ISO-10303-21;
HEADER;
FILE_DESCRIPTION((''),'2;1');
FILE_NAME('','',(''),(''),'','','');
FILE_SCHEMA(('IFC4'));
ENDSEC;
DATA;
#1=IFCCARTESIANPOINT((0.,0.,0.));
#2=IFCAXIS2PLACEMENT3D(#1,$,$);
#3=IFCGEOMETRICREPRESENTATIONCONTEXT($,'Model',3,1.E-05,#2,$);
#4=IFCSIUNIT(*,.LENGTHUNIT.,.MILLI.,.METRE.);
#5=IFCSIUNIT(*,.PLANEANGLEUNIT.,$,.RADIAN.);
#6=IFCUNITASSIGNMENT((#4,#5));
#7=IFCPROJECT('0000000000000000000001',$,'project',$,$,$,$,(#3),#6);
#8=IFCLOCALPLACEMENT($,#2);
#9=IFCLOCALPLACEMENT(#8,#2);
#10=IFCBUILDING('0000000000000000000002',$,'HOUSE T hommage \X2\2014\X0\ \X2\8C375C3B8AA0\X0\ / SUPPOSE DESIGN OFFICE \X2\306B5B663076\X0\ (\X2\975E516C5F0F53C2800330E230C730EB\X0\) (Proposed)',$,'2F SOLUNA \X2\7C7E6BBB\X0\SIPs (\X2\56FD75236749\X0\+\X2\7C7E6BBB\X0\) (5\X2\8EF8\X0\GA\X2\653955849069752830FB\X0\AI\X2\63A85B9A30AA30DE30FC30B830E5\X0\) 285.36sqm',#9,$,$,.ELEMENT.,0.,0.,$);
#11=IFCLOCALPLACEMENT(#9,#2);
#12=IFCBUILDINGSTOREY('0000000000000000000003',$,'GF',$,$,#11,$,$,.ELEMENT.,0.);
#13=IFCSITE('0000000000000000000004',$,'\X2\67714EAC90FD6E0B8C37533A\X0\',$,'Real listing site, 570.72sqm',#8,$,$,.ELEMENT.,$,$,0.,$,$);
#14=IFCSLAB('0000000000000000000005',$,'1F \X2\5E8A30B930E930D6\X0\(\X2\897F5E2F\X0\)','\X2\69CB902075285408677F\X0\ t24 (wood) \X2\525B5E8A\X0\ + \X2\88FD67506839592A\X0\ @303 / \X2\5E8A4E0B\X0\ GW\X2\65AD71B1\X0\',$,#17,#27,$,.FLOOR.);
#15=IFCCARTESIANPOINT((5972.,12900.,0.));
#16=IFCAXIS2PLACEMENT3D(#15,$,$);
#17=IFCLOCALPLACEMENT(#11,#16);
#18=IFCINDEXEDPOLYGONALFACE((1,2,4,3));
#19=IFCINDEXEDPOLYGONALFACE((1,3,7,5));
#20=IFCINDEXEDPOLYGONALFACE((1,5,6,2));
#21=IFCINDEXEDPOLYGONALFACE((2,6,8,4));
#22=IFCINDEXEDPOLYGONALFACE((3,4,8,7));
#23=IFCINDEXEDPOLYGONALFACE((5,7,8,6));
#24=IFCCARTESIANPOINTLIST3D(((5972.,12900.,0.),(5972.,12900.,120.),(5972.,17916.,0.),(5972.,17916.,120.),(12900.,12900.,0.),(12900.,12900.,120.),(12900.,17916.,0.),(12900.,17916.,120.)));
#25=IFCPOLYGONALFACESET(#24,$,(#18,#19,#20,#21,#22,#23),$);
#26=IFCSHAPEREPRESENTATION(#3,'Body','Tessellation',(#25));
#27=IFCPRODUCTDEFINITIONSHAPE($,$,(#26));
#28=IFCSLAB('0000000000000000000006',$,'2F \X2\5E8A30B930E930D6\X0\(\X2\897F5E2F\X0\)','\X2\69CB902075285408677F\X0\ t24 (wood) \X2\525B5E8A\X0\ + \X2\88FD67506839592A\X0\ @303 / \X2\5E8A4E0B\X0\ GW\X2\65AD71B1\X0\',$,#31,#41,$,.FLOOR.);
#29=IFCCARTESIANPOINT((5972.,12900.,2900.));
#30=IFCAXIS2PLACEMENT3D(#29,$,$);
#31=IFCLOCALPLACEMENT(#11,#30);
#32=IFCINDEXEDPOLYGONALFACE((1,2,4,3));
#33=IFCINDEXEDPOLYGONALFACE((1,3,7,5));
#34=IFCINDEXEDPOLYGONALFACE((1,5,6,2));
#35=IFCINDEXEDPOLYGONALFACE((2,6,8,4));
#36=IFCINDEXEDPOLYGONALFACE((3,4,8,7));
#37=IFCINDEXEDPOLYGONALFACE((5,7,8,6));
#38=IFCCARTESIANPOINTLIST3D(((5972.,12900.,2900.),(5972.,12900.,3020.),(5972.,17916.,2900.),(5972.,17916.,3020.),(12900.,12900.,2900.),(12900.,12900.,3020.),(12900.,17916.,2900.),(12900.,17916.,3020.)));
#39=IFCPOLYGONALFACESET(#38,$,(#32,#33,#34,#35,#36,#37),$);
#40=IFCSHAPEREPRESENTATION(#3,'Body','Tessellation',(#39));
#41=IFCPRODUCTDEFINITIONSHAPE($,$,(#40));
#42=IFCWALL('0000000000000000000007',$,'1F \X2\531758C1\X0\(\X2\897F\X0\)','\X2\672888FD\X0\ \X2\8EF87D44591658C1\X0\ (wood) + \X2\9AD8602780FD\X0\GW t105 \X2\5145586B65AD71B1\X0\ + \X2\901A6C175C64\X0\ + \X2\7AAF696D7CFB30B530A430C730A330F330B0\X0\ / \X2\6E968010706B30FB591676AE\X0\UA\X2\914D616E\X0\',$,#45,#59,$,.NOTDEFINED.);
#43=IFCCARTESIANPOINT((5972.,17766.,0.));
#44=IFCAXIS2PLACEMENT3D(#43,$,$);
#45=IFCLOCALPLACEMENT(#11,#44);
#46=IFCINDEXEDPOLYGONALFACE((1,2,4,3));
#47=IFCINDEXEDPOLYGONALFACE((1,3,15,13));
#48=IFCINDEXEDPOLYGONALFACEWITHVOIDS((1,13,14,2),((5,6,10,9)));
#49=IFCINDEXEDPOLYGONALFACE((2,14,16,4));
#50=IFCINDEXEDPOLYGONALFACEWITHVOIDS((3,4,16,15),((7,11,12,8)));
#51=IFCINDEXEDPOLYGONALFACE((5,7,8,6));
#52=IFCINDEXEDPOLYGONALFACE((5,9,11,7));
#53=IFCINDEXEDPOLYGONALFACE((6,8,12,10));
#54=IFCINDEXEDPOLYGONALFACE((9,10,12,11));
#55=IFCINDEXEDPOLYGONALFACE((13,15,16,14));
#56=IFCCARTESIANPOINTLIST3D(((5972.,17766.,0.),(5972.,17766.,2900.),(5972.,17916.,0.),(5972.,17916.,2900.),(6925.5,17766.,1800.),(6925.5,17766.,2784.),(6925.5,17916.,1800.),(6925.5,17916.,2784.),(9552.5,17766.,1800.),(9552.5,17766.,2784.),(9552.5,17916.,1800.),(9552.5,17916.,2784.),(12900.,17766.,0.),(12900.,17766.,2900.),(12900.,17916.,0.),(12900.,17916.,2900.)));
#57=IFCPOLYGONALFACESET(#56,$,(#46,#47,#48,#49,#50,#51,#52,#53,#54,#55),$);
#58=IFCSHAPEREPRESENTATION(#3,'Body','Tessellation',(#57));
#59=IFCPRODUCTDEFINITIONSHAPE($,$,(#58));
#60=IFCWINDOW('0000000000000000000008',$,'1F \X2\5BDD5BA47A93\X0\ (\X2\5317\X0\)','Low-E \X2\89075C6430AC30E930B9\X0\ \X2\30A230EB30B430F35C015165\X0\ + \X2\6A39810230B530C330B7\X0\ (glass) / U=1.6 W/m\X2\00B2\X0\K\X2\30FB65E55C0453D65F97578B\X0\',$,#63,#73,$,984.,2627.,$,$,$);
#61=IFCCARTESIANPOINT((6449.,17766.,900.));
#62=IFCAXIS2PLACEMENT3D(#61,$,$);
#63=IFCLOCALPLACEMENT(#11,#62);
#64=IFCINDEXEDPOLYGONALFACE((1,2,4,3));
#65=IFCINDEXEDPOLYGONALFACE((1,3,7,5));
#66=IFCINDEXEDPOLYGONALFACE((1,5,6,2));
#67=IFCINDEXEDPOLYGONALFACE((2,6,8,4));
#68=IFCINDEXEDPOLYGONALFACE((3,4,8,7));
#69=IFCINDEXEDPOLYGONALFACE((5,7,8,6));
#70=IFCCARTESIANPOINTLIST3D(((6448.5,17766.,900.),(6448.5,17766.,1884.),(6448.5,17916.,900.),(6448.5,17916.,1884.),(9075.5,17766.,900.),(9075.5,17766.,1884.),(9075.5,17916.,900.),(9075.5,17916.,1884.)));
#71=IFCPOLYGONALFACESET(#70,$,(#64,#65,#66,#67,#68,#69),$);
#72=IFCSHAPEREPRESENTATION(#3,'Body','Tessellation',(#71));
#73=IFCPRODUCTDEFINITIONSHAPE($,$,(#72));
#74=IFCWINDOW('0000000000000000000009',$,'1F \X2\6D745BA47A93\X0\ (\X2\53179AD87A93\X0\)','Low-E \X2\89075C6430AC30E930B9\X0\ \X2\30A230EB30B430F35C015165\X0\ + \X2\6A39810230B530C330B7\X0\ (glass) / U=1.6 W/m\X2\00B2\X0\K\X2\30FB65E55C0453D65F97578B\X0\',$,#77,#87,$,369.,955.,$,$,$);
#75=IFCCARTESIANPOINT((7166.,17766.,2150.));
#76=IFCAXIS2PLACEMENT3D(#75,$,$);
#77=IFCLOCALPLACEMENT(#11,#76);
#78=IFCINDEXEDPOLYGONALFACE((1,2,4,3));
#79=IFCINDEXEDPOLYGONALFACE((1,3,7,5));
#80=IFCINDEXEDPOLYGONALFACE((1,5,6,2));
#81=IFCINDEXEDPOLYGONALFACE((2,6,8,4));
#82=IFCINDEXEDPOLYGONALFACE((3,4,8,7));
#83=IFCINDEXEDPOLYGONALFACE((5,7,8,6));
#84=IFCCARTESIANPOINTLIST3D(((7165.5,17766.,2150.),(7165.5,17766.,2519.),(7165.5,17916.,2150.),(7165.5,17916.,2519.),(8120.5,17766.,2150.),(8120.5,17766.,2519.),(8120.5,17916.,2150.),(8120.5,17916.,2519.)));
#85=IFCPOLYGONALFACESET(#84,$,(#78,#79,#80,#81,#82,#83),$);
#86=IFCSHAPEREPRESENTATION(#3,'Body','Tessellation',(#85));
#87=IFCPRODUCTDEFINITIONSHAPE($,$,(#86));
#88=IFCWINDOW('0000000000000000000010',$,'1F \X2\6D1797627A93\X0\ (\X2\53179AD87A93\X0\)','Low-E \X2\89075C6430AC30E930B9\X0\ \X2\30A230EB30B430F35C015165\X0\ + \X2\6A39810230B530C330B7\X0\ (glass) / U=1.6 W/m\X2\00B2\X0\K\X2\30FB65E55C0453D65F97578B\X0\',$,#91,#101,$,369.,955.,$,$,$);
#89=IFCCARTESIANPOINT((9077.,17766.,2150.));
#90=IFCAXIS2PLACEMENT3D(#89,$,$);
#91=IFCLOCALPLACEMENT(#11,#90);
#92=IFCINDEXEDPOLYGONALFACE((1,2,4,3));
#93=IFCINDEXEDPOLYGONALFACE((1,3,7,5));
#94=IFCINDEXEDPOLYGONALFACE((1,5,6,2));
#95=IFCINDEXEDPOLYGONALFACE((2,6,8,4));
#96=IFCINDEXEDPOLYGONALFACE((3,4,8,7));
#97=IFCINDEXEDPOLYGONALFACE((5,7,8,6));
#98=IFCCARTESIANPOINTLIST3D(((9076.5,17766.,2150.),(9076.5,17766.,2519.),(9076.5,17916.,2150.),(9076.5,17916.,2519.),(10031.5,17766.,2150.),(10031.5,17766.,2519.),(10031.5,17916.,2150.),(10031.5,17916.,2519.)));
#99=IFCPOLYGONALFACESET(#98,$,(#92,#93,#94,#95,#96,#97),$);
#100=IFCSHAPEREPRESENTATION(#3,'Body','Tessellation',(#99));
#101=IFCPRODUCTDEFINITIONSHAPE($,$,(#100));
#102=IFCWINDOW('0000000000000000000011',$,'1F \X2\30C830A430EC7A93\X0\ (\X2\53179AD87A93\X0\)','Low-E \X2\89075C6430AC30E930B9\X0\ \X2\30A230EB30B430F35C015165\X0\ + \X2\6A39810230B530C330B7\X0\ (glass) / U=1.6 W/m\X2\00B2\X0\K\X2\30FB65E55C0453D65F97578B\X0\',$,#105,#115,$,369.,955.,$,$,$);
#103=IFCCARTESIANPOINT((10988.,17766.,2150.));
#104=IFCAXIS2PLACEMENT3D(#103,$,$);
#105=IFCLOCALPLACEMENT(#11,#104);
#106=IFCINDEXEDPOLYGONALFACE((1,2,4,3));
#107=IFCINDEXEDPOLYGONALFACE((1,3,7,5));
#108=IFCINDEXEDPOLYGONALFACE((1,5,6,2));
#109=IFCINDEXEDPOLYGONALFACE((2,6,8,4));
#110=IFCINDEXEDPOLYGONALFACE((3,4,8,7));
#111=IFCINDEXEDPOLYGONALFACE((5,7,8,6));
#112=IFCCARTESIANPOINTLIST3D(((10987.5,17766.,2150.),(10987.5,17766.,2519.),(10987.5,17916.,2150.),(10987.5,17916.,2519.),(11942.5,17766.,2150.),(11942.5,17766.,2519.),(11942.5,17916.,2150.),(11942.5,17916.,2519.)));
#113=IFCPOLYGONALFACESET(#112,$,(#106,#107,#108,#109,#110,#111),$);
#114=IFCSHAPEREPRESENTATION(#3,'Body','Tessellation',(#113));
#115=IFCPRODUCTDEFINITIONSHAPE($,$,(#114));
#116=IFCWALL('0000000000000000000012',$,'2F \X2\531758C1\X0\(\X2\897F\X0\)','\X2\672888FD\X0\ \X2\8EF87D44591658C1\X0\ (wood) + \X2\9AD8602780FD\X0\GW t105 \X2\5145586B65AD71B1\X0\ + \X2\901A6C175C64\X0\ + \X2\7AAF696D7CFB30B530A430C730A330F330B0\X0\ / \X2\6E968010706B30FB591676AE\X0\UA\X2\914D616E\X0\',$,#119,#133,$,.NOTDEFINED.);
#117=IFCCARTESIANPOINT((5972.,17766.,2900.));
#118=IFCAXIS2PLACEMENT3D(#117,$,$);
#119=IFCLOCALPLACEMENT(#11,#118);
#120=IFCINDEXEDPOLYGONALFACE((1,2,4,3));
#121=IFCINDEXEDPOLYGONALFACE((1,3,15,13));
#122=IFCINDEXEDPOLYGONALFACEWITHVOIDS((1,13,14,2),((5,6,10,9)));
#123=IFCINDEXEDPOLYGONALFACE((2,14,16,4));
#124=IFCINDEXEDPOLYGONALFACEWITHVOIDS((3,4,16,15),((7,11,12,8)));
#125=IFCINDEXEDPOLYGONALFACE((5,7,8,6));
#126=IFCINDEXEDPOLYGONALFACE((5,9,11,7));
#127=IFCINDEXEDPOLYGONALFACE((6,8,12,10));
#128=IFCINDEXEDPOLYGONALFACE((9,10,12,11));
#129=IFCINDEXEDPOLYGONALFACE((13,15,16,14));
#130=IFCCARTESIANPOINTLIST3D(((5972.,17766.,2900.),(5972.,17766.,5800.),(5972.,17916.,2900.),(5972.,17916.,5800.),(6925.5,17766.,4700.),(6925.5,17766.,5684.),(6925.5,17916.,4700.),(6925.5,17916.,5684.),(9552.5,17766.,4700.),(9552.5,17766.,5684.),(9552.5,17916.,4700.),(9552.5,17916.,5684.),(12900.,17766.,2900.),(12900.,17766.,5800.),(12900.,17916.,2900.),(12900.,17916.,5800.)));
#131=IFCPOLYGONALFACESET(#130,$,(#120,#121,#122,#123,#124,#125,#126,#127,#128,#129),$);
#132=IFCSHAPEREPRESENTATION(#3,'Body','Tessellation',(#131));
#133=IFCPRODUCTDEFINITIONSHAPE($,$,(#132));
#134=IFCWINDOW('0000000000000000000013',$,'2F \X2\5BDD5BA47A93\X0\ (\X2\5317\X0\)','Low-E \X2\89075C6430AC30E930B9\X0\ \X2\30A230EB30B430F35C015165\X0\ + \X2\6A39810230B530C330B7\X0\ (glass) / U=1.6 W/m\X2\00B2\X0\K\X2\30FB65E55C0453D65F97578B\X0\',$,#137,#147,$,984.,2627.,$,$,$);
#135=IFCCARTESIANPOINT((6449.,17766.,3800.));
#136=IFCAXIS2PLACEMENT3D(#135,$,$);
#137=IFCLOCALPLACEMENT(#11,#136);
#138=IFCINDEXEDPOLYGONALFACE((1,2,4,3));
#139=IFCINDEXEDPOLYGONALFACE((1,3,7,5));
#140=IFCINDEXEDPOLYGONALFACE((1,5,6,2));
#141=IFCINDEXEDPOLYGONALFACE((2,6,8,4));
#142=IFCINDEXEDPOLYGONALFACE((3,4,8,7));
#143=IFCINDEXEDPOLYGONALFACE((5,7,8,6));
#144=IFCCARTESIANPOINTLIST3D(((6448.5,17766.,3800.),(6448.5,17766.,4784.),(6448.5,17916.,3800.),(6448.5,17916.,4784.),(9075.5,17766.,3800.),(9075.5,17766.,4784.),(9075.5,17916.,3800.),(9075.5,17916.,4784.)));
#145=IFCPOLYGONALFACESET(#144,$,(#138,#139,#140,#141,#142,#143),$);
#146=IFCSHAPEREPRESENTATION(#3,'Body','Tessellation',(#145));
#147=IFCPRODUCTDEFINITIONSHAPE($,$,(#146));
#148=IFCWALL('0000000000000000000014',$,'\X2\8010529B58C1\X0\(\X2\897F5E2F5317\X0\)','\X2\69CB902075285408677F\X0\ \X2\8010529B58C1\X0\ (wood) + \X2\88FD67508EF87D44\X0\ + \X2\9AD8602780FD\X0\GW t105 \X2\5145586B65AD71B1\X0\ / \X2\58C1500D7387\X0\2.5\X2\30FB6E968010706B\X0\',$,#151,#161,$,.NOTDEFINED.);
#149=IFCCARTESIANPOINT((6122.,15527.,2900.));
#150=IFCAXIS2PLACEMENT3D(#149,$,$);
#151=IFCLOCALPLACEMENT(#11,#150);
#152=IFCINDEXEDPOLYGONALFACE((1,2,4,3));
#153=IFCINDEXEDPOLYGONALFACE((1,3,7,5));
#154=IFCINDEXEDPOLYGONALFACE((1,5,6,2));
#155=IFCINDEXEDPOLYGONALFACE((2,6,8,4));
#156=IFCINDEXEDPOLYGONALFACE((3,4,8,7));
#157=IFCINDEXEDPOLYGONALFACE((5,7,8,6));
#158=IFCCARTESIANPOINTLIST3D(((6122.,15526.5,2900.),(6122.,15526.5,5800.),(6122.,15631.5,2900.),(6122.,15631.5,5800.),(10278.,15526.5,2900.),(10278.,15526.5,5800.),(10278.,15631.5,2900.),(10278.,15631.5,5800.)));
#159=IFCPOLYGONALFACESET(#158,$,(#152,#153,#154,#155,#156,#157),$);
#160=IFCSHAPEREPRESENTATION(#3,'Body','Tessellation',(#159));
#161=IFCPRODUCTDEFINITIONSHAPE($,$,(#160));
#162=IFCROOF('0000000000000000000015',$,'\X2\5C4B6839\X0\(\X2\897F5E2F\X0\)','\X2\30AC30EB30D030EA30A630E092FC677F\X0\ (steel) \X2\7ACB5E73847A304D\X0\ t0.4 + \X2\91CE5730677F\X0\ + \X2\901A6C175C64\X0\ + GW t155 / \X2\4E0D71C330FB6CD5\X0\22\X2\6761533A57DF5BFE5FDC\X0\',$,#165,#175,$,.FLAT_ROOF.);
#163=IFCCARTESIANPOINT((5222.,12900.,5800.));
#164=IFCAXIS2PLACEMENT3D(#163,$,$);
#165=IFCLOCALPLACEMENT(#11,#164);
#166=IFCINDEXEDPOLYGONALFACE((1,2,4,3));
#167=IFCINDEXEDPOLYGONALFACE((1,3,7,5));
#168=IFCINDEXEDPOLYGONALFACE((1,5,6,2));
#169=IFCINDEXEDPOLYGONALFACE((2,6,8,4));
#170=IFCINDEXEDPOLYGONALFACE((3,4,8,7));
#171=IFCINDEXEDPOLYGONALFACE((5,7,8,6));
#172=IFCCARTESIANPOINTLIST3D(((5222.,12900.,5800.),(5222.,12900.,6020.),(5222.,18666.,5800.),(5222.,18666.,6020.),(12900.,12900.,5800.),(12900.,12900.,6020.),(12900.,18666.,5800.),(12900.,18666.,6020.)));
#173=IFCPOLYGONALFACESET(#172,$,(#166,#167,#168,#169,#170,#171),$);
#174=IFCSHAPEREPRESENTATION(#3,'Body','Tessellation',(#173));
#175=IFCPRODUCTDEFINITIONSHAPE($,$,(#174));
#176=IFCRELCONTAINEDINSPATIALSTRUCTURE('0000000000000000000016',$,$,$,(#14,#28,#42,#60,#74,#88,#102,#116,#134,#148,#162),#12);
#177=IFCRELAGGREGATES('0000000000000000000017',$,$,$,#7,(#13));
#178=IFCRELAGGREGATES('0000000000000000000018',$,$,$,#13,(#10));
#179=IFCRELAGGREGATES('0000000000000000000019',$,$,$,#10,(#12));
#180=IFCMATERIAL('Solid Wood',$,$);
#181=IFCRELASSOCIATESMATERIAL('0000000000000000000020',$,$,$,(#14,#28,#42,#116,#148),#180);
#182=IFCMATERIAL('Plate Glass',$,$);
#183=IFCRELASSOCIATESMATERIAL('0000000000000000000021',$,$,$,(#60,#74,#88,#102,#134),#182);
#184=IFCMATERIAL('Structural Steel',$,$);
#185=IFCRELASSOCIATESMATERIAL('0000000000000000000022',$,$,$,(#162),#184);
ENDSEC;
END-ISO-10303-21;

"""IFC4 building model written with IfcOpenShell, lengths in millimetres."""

from ifc_helpers import new_model, si_unit, frame, frame_2d, origin, place, context, project, spatial, rectangle, extrude, material, element, fill, save


model = new_model("IFC4")

# Units and contexts
model_context = context("Model", 3, precision=1e-05, world=origin())
ifc_project = project(units=[si_unit("LENGTHUNIT", "METRE", prefix="MILLI"), si_unit("PLANEANGLEUNIT", "RADIAN")], contexts=[model_context])

# Site, building, storey
site_placement = place(None, origin())
site = spatial("IfcSite", under=ifc_project, at=site_placement, Name="東京都渋谷区", ObjectType="Real listing site, 570.72sqm", CompositionType="ELEMENT", RefElevation=0.0)
building_placement = place(site_placement, origin())
building = spatial("IfcBuilding", under=site, at=building_placement, Name="HOUSE T hommage — 谷尻誠 / SUPPOSE DESIGN OFFICE に学ぶ (非公式参考モデル) (Proposed)", ObjectType="2F SOLUNA 籾殻SIPs (国産杉+籾殻) (5軸GA改善適用・AI推定オマージュ) 285.36sqm", CompositionType="ELEMENT", ElevationOfRefHeight=0.0, ElevationOfTerrain=0.0)
storey_placement = place(building_placement, origin())
storey = spatial("IfcBuildingStorey", under=building, at=storey_placement, Name="GF", CompositionType="ELEMENT", Elevation=0.0)

# Slabs
ifc_material_1 = material(Name="Solid Wood")
slab_1_placement = place(storey_placement, frame((5972.0, 12900.0, 0.0)))
element("IfcSlab", 1, at=slab_1_placement, inside=storey, material=ifc_material_1, Name="1F 床スラブ(西帯)", Description="構造用合板 t24 (wood) 剛床 + 製材根太 @303 / 床下 GW断熱", PredefinedType="FLOOR", context=model_context, shape_type="SweptSolid", body=[
    extrude(rectangle(XDim=6928.0, YDim=5016.0, at=frame_2d((3464.0, 2508.0))), frame((5972.0, 12900.0, 0.0)), (0.0, 0.0, 1.0), 120.0),
])
slab_2_placement = place(storey_placement, frame((5972.0, 12900.0, 2900.0)))
element("IfcSlab", 2, at=slab_2_placement, inside=storey, material=ifc_material_1, Name="2F 床スラブ(西帯)", Description="構造用合板 t24 (wood) 剛床 + 製材根太 @303 / 床下 GW断熱", PredefinedType="FLOOR", context=model_context, shape_type="SweptSolid", body=[
    extrude(rectangle(XDim=6928.0, YDim=5016.0, at=frame_2d((3464.0, 2508.0))), frame((5972.0, 12900.0, 2900.0)), (0.0, 0.0, 1.0), 120.0),
])

# Wall, openings, windows
wall_1_placement = place(storey_placement, frame((5972.0, 17766.0, 0.0)))
wall_1 = element("IfcWall", 3, at=wall_1_placement, inside=storey, material=ifc_material_1, Name="1F 北壁(西)", Description="木製 軸組外壁 (wood) + 高性能GW t105 充填断熱 + 通気層 + 窯業系サイディング / 準耐火・外皮UA配慮", PredefinedType="NOTDEFINED", context=model_context, shape_type="SweptSolid", body=[
    extrude(rectangle(XDim=6928.0, YDim=150.0, at=frame_2d((3464.0, 75.0))), frame((5972.0, 17766.0, 0.0)), (0.0, 0.0, 1.0), 2900.0),
])
opening_1_placement = place(storey_placement, frame((6449.0, 17766.0, 900.0)))
opening_1 = element("IfcOpeningElement", 4, at=opening_1_placement, cuts=wall_1, PredefinedType="NOTDEFINED", context=model_context, shape_type="SweptSolid", body=[
    extrude(rectangle(XDim=2627.0, YDim=150.0, at=frame_2d((1313.0, 75.0))), frame((6449.0, 17766.0, 900.0)), (0.0, 0.0, 1.0), 984.0),
])
opening_2_placement = place(storey_placement, frame((7166.0, 17766.0, 2150.0)))
opening_2 = element("IfcOpeningElement", 5, at=opening_2_placement, cuts=wall_1, PredefinedType="NOTDEFINED", context=model_context, shape_type="SweptSolid", body=[
    extrude(rectangle(XDim=955.0, YDim=150.0, at=frame_2d((477.0, 75.0))), frame((7166.0, 17766.0, 2150.0)), (0.0, 0.0, 1.0), 369.0),
])
opening_3_placement = place(storey_placement, frame((9077.0, 17766.0, 2150.0)))
opening_3 = element("IfcOpeningElement", 6, at=opening_3_placement, cuts=wall_1, PredefinedType="NOTDEFINED", context=model_context, shape_type="SweptSolid", body=[
    extrude(rectangle(XDim=955.0, YDim=150.0, at=frame_2d((477.0, 75.0))), frame((9077.0, 17766.0, 2150.0)), (0.0, 0.0, 1.0), 369.0),
])
opening_4_placement = place(storey_placement, frame((10988.0, 17766.0, 2150.0)))
opening_4 = element("IfcOpeningElement", 7, at=opening_4_placement, cuts=wall_1, PredefinedType="NOTDEFINED", context=model_context, shape_type="SweptSolid", body=[
    extrude(rectangle(XDim=955.0, YDim=150.0, at=frame_2d((477.0, 75.0))), frame((10988.0, 17766.0, 2150.0)), (0.0, 0.0, 1.0), 369.0),
])
ifc_material_2 = material(Name="Plate Glass")
window_1_placement = place(storey_placement, frame((6449.0, 17766.0, 900.0)))
window_1 = element("IfcWindow", 8, at=window_1_placement, inside=storey, material=ifc_material_2, Name="1F 寝室窓 (北)", Description="Low-E 複層ガラス アルゴン封入 + 樹脂サッシ (glass) / U=1.6 W/m²K・日射取得型", OverallHeight=984.0, OverallWidth=2627.0, context=model_context, shape_type="SweptSolid", body=[
    extrude(rectangle(XDim=2627.0, YDim=150.0, at=frame_2d((1313.0, 75.0))), frame((6449.0, 17766.0, 900.0)), (0.0, 0.0, 1.0), 984.0),
])
fill(opening_1, window_1)
window_2_placement = place(storey_placement, frame((7166.0, 17766.0, 2150.0)))
window_2 = element("IfcWindow", 9, at=window_2_placement, inside=storey, material=ifc_material_2, Name="1F 浴室窓 (北高窓)", Description="Low-E 複層ガラス アルゴン封入 + 樹脂サッシ (glass) / U=1.6 W/m²K・日射取得型", OverallHeight=369.0, OverallWidth=955.0, context=model_context, shape_type="SweptSolid", body=[
    extrude(rectangle(XDim=955.0, YDim=150.0, at=frame_2d((477.0, 75.0))), frame((7166.0, 17766.0, 2150.0)), (0.0, 0.0, 1.0), 369.0),
])
fill(opening_2, window_2)
window_3_placement = place(storey_placement, frame((9077.0, 17766.0, 2150.0)))
window_3 = element("IfcWindow", 10, at=window_3_placement, inside=storey, material=ifc_material_2, Name="1F 洗面窓 (北高窓)", Description="Low-E 複層ガラス アルゴン封入 + 樹脂サッシ (glass) / U=1.6 W/m²K・日射取得型", OverallHeight=369.0, OverallWidth=955.0, context=model_context, shape_type="SweptSolid", body=[
    extrude(rectangle(XDim=955.0, YDim=150.0, at=frame_2d((477.0, 75.0))), frame((9077.0, 17766.0, 2150.0)), (0.0, 0.0, 1.0), 369.0),
])
fill(opening_3, window_3)
window_4_placement = place(storey_placement, frame((10988.0, 17766.0, 2150.0)))
window_4 = element("IfcWindow", 11, at=window_4_placement, inside=storey, material=ifc_material_2, Name="1F トイレ窓 (北高窓)", Description="Low-E 複層ガラス アルゴン封入 + 樹脂サッシ (glass) / U=1.6 W/m²K・日射取得型", OverallHeight=369.0, OverallWidth=955.0, context=model_context, shape_type="SweptSolid", body=[
    extrude(rectangle(XDim=955.0, YDim=150.0, at=frame_2d((477.0, 75.0))), frame((10988.0, 17766.0, 2150.0)), (0.0, 0.0, 1.0), 369.0),
])
fill(opening_4, window_4)

# Wall, opening, window
wall_2_placement = place(storey_placement, frame((5972.0, 17766.0, 2900.0)))
wall_2 = element("IfcWall", 12, at=wall_2_placement, inside=storey, material=ifc_material_1, Name="2F 北壁(西)", Description="木製 軸組外壁 (wood) + 高性能GW t105 充填断熱 + 通気層 + 窯業系サイディング / 準耐火・外皮UA配慮", PredefinedType="NOTDEFINED", context=model_context, shape_type="SweptSolid", body=[
    extrude(rectangle(XDim=6928.0, YDim=150.0, at=frame_2d((3464.0, 75.0))), frame((5972.0, 17766.0, 2900.0)), (0.0, 0.0, 1.0), 2900.0),
])
opening_5_placement = place(storey_placement, frame((6449.0, 17766.0, 3800.0)))
opening_5 = element("IfcOpeningElement", 13, at=opening_5_placement, cuts=wall_2, PredefinedType="NOTDEFINED", context=model_context, shape_type="SweptSolid", body=[
    extrude(rectangle(XDim=2627.0, YDim=150.0, at=frame_2d((1313.0, 75.0))), frame((6449.0, 17766.0, 3800.0)), (0.0, 0.0, 1.0), 984.0),
])
window_5_placement = place(storey_placement, frame((6449.0, 17766.0, 3800.0)))
window_5 = element("IfcWindow", 14, at=window_5_placement, inside=storey, material=ifc_material_2, Name="2F 寝室窓 (北)", Description="Low-E 複層ガラス アルゴン封入 + 樹脂サッシ (glass) / U=1.6 W/m²K・日射取得型", OverallHeight=984.0, OverallWidth=2627.0, context=model_context, shape_type="SweptSolid", body=[
    extrude(rectangle(XDim=2627.0, YDim=150.0, at=frame_2d((1313.0, 75.0))), frame((6449.0, 17766.0, 3800.0)), (0.0, 0.0, 1.0), 984.0),
])
fill(opening_5, window_5)

# Wall
wall_3_placement = place(storey_placement, frame((6122.0, 15527.0, 2900.0)))
element("IfcWall", 15, at=wall_3_placement, inside=storey, material=ifc_material_1, Name="耐力壁(西帯北)", Description="構造用合板 耐力壁 (wood) + 製材軸組 + 高性能GW t105 充填断熱 / 壁倍率2.5・準耐火", PredefinedType="NOTDEFINED", context=model_context, shape_type="SweptSolid", body=[
    extrude(rectangle(XDim=4156.0, YDim=105.0, at=frame_2d((2078.0, 52.0))), frame((6122.0, 15527.0, 2900.0)), (0.0, 0.0, 1.0), 2900.0),
])

# Roof
ifc_material_3 = material(Name="Structural Steel")
for number, where, name in (
    (16, (5222.0, 12900.0, 5800.0), "屋根(西帯)"),
):
    element("IfcRoof", number, at=place(storey_placement, frame(where)), inside=storey, material=ifc_material_3, Name=name, Description="ガルバリウム鋼板 (steel) 立平葺き t0.4 + 野地板 + 通気層 + GW t155 / 不燃・法22条区域対応", PredefinedType="FLAT_ROOF", context=model_context, shape_type="SweptSolid", body=[
        extrude(rectangle(XDim=7678.0, YDim=5766.0, at=frame_2d((3839.0, 2883.0))), frame((5222.0, 12900.0, 5800.0)), (0.0, 0.0, 1.0), 220.0),
    ])

save(model, "model.ifc")
